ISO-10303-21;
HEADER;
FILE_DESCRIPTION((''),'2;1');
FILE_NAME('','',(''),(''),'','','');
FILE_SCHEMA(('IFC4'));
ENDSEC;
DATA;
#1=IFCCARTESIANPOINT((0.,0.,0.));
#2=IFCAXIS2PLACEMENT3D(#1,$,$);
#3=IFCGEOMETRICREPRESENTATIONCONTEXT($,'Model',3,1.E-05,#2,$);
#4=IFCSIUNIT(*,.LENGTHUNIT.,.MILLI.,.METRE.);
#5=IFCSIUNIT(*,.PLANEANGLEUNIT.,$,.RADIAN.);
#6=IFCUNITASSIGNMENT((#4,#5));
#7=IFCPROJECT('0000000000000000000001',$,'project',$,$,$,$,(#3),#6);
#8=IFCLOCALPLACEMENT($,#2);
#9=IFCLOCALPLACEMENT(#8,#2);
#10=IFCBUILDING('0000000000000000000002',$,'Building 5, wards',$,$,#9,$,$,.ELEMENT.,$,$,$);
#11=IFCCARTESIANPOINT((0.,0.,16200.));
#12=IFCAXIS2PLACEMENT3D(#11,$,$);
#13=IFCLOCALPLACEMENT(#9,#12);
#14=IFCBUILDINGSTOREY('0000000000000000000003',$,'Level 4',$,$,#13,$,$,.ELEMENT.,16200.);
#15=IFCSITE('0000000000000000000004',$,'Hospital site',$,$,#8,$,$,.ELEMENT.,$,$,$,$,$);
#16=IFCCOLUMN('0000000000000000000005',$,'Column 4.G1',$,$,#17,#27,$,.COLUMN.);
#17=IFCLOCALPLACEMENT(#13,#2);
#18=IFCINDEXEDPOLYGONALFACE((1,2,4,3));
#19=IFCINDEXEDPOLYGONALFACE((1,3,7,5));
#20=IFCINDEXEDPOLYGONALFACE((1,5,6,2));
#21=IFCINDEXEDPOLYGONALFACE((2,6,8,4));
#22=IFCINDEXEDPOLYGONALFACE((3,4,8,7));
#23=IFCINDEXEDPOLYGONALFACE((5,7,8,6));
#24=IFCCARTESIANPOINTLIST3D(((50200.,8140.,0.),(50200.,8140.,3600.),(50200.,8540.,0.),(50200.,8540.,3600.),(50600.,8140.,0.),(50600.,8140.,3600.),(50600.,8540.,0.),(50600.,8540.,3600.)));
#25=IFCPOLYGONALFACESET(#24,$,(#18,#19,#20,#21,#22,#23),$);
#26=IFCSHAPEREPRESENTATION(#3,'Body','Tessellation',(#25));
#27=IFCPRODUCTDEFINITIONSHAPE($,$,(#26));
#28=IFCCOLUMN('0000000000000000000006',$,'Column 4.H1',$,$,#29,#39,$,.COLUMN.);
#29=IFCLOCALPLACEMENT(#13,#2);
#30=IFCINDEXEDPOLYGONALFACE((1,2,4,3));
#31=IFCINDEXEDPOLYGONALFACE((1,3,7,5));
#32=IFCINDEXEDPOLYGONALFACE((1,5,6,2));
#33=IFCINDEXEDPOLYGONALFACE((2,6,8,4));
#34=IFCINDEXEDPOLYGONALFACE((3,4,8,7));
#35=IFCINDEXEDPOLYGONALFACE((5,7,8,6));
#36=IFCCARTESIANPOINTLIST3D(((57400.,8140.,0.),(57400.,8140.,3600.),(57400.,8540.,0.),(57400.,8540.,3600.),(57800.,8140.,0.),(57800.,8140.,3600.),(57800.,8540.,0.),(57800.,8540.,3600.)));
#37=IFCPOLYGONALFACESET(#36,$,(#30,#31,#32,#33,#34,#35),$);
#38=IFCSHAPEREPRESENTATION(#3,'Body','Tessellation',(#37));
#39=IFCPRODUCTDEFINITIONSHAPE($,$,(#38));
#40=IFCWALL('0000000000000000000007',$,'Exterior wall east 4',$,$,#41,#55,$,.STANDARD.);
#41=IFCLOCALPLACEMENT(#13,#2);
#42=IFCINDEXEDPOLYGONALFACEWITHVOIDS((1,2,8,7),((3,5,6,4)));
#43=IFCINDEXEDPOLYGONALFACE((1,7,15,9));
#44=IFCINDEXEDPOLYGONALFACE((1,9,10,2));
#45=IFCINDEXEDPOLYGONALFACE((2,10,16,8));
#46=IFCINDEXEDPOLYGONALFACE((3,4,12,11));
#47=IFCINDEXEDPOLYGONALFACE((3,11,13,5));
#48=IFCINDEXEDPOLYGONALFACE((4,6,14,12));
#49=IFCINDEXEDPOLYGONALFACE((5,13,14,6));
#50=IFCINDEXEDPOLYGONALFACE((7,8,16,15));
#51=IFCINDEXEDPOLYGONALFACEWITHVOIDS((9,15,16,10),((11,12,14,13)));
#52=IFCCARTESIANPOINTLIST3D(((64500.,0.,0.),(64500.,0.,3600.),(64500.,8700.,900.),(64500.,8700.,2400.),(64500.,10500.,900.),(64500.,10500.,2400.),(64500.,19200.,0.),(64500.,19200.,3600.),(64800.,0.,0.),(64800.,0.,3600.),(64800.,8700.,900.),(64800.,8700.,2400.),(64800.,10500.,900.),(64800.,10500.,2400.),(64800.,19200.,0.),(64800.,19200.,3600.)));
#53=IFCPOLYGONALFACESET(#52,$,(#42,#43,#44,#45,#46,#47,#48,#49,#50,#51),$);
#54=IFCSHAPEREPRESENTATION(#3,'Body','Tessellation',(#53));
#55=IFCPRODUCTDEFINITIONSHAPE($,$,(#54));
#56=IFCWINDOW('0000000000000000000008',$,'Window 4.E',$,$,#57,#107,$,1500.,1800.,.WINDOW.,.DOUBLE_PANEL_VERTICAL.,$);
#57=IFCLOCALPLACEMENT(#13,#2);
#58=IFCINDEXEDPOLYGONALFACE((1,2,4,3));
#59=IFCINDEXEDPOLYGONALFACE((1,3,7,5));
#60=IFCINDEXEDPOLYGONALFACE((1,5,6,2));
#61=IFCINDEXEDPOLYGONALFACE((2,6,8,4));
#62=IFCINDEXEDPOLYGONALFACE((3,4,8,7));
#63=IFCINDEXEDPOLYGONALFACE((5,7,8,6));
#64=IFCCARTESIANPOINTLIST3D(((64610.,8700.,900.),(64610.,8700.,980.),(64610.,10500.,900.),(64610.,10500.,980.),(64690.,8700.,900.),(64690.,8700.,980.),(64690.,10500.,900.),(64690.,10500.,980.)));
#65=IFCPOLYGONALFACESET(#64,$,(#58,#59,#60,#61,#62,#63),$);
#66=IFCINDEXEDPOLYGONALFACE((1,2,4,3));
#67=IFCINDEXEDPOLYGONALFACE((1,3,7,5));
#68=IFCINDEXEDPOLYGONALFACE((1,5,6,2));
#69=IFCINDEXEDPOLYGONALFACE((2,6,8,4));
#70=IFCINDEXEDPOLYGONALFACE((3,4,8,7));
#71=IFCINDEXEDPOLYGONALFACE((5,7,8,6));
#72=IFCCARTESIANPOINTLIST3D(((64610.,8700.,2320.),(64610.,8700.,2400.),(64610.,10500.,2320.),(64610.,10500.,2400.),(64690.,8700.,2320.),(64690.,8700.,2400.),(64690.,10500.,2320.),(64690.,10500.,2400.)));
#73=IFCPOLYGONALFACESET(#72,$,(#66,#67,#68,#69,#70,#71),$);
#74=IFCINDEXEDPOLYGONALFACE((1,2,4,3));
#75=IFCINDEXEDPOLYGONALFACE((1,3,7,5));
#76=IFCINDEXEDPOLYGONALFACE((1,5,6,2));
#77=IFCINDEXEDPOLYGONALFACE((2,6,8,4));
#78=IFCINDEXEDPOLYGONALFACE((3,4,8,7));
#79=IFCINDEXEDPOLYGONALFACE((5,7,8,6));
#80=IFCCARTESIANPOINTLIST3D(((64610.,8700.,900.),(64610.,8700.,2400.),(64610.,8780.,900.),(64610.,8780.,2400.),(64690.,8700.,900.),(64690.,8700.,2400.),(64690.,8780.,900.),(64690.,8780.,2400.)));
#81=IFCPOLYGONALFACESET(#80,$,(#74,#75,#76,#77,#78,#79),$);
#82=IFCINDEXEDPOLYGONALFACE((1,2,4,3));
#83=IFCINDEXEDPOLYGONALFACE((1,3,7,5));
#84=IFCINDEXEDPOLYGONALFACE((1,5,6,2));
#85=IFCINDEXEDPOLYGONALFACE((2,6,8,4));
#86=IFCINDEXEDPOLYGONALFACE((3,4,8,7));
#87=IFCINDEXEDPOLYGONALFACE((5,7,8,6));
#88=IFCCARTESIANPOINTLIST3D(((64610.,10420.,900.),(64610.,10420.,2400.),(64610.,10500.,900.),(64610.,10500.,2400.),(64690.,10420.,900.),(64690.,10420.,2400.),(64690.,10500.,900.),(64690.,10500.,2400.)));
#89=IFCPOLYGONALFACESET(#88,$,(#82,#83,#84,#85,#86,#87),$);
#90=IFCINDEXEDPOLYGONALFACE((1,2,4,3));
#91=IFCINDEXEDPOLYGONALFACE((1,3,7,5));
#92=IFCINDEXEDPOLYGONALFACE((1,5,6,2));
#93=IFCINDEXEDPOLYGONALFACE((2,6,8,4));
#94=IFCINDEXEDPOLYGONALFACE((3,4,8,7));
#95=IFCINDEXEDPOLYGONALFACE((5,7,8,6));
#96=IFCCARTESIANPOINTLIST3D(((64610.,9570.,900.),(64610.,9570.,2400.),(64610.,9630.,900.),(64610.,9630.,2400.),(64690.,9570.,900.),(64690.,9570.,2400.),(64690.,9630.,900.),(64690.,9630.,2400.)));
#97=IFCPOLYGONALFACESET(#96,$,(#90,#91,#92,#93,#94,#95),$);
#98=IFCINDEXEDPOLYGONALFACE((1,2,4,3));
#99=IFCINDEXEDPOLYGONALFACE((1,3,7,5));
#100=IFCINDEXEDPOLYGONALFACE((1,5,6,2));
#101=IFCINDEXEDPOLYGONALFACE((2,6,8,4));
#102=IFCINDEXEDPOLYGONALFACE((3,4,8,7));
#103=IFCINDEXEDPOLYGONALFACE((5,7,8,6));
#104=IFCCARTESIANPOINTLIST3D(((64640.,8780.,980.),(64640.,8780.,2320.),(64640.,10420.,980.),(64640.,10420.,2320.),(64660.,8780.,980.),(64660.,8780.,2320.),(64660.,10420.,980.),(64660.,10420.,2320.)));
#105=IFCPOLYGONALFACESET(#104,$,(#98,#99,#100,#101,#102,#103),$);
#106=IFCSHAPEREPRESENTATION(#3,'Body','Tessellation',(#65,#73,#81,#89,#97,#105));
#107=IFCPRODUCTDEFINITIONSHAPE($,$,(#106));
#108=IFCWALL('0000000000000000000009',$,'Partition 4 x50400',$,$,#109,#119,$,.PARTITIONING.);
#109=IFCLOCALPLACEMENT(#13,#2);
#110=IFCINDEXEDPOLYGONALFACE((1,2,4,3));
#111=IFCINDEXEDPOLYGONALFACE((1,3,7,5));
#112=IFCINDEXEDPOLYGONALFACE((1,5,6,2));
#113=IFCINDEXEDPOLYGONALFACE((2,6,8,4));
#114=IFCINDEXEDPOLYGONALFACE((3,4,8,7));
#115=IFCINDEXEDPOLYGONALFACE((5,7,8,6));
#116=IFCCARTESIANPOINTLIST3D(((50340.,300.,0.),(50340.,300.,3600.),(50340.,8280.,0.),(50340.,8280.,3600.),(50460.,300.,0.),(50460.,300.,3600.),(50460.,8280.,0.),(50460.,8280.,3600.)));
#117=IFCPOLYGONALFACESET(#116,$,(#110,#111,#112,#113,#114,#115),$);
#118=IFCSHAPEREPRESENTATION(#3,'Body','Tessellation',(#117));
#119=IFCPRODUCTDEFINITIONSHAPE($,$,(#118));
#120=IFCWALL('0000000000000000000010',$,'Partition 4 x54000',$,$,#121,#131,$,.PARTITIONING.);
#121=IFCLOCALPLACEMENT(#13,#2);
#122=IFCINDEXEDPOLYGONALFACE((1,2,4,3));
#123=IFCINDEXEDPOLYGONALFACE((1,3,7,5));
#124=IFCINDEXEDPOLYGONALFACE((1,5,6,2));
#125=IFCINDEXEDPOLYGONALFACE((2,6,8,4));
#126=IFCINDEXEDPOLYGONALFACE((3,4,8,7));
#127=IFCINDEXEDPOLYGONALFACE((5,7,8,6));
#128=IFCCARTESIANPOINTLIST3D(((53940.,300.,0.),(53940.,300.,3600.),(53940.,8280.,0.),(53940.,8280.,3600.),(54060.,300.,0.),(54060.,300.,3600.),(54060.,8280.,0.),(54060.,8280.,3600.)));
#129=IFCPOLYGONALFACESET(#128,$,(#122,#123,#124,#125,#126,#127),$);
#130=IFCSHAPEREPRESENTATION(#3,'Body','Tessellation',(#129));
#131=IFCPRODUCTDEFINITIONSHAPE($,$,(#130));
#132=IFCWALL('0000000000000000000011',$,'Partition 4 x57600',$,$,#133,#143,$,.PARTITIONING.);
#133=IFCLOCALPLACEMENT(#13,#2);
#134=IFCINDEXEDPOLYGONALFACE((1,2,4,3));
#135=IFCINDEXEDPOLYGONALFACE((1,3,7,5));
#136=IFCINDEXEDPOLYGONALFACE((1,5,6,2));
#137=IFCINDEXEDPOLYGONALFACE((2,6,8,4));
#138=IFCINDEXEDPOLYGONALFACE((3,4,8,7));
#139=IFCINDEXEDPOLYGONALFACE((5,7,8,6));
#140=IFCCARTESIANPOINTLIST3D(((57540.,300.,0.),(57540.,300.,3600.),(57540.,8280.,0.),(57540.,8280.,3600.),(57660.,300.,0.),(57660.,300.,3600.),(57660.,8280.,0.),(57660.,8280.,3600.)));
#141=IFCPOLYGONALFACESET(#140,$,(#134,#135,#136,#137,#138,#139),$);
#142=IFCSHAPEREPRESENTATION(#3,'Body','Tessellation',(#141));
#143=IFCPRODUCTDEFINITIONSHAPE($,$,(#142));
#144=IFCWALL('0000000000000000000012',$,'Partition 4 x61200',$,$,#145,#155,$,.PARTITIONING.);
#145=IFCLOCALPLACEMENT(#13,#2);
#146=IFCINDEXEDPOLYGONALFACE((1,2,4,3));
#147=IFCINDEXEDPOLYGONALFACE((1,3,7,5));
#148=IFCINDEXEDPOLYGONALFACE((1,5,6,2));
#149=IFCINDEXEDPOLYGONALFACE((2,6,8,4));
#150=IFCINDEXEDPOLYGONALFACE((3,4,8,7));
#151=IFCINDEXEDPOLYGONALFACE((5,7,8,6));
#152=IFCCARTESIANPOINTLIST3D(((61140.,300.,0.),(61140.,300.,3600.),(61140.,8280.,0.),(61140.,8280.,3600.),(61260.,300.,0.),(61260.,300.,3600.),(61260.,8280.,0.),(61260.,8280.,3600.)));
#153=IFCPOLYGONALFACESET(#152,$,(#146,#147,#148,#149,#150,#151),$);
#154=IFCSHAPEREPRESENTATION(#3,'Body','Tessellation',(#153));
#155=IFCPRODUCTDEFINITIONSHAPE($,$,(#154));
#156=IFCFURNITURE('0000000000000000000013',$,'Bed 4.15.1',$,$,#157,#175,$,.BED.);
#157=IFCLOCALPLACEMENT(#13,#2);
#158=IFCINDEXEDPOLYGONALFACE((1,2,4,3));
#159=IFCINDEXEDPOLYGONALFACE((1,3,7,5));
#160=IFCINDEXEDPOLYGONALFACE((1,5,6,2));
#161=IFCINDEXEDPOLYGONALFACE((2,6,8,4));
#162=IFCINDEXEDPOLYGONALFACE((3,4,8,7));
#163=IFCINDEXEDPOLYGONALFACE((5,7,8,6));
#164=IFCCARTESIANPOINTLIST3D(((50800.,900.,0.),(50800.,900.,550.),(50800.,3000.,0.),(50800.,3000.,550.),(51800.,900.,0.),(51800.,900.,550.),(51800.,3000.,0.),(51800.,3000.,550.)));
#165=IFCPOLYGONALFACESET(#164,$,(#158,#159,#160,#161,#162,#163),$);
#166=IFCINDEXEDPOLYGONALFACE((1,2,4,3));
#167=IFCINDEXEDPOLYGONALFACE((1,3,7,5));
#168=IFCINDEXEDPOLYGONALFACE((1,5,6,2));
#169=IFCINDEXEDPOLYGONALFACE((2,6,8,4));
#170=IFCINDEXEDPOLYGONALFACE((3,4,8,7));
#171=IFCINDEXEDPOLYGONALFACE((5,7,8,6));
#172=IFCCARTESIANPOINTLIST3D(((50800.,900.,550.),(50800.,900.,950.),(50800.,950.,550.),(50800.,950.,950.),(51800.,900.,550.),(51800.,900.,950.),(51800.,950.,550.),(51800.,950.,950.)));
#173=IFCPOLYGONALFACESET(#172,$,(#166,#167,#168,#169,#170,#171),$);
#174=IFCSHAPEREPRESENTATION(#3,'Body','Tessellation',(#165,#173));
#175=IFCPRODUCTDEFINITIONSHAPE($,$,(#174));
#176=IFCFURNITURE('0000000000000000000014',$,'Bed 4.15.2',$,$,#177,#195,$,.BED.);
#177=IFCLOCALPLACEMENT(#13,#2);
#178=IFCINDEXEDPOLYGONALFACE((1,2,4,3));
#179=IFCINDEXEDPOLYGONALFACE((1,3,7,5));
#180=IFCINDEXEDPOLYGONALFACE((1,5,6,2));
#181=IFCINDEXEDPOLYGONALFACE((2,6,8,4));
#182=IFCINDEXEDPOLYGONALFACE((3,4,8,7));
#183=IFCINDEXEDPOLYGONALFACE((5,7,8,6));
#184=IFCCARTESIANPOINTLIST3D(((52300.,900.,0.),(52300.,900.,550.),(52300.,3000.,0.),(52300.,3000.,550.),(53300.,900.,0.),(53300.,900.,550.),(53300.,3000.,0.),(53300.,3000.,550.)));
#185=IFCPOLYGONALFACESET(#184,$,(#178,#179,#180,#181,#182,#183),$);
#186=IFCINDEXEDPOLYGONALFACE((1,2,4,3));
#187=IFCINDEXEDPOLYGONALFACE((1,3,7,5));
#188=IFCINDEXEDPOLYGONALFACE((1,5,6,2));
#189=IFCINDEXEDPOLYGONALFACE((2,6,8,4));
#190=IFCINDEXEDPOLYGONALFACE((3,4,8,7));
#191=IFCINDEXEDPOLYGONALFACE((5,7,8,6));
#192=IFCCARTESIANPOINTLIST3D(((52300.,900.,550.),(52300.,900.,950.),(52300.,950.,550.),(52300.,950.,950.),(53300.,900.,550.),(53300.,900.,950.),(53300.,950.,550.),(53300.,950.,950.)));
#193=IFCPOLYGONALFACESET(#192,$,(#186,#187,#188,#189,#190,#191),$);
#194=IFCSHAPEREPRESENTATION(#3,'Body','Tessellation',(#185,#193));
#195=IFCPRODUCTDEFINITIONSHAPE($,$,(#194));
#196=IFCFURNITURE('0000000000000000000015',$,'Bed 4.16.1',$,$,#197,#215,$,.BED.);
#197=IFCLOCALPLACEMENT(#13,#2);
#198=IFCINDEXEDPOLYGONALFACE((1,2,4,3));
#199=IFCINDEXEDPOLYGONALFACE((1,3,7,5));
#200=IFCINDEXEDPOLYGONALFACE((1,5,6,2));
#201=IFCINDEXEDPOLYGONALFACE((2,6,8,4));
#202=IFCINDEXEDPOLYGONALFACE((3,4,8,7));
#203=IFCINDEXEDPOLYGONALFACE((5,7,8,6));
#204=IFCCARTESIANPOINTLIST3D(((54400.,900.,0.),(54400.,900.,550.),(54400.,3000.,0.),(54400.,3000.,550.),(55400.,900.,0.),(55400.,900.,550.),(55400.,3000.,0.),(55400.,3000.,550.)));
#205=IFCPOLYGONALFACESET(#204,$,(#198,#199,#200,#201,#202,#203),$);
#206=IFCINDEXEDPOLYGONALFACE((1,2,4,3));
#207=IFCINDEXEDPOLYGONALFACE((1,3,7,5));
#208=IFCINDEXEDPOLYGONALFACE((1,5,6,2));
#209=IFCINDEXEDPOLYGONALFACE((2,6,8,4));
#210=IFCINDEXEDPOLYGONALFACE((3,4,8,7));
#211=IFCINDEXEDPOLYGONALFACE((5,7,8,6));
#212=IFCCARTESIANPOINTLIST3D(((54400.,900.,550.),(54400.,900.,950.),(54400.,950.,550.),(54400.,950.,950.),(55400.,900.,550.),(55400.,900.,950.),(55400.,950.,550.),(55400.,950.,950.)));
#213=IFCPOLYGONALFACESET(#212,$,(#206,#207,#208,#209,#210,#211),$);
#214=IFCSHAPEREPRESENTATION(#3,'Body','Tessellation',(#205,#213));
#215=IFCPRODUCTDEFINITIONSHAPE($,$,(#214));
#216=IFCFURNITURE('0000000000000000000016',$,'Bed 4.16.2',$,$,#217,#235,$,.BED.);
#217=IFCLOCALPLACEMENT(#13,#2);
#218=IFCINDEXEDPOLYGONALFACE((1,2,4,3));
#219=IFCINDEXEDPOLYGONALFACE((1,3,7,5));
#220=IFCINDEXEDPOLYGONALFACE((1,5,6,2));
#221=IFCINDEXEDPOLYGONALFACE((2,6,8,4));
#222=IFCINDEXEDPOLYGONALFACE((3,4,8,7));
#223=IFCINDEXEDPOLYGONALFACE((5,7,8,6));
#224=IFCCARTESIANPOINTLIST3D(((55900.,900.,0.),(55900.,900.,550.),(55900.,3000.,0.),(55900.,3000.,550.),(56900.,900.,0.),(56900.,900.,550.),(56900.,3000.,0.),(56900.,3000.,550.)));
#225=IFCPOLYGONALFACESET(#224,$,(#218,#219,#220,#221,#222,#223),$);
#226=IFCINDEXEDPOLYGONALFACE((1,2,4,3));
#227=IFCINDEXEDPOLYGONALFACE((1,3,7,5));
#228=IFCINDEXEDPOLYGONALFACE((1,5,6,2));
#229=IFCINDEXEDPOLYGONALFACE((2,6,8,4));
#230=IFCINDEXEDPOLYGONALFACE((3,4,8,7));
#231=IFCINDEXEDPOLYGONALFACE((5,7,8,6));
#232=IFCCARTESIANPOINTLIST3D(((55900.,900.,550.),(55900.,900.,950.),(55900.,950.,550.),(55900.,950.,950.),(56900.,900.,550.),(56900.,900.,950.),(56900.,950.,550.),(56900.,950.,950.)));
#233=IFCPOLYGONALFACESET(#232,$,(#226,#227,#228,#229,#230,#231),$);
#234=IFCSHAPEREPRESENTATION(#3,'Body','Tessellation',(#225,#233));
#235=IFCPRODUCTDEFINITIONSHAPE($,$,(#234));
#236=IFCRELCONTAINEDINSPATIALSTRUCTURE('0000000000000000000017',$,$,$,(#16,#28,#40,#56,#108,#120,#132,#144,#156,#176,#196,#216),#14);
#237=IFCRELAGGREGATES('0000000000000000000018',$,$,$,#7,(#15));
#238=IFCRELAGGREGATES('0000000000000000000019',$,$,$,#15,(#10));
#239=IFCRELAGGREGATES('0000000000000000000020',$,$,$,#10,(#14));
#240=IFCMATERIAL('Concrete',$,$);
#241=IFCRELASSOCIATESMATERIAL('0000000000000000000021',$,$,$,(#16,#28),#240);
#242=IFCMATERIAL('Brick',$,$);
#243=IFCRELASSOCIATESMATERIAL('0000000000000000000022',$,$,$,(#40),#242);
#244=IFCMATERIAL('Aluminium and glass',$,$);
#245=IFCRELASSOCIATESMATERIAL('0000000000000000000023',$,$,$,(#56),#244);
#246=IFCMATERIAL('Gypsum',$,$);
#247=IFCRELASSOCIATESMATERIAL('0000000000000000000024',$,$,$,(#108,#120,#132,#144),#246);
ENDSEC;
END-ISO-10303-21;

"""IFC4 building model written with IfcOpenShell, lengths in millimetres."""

from ifc_helpers import new_model, si_unit, frame, frame_2d, origin, origin_2d, place, context, project, spatial, rectangle, extrude, material, element, fill, save


model = new_model("IFC4")

# Units and contexts
model_context = context("Model", 3, precision=1e-05, world=origin())
ifc_project = project(units=[si_unit("LENGTHUNIT", "METRE", prefix="MILLI"), si_unit("PLANEANGLEUNIT", "RADIAN")], contexts=[model_context])

# Site, building, storey
site_placement = place(None, origin())
site = spatial("IfcSite", under=ifc_project, at=site_placement, Name="Hospital site", CompositionType="ELEMENT")
building_placement = place(site_placement, origin())
building = spatial("IfcBuilding", under=site, at=building_placement, Name="Building 5, wards", CompositionType="ELEMENT")
storey_placement = place(building_placement, frame((0.0, 0.0, 16200.0)))
storey = spatial("IfcBuildingStorey", under=building, at=storey_placement, Name="Level 4", CompositionType="ELEMENT", Elevation=16200.0)

# Columns
ifc_material_1 = material(Name="Concrete")
for number, where, name in (
    (1, (50400.0, 8340.0, 0.0), "Column 4.G1"),
    (2, (57600.0, 8340.0, 0.0), "Column 4.H1"),
):
    element("IfcColumn", number, at=place(storey_placement, frame(where)), inside=storey, material=ifc_material_1, Name=name, PredefinedType="COLUMN", context=model_context, shape_type="SweptSolid", body=[
        extrude(rectangle(XDim=400.0, YDim=400.0, at=origin_2d()), origin(), (0.0, 0.0, 1.0), 3600.0),
    ])

# Wall, opening, window
ifc_material_2 = material(Name="Brick")
wall_placement = place(storey_placement, frame((64800.0, 0.0, 0.0), x_axis=(0.0, 1.0, 0.0)))
wall = element("IfcWall", 3, at=wall_placement, inside=storey, material=ifc_material_2, Name="Exterior wall east 4", PredefinedType="STANDARD", context=model_context, shape_type="SweptSolid", body=[
    extrude(rectangle(XDim=19200.0, YDim=300.0, at=frame_2d((9600.0, 150.0))), origin(), (0.0, 0.0, 1.0), 3600.0),
])
opening_placement = place(wall_placement, frame((8700.0, -50.0, 900.0)))
opening = element("IfcOpeningElement", 4, at=opening_placement, cuts=wall, PredefinedType="OPENING", context=model_context, shape_type="SweptSolid", body=[
    extrude(rectangle(XDim=1800.0, YDim=400.0, at=frame_2d((900.0, 200.0))), origin(), (0.0, 0.0, 1.0), 1500.0),
])
ifc_material_3 = material(Name="Aluminium and glass")
window_placement = place(opening_placement, frame((0.0, 160.0, 0.0)))
window = element("IfcWindow", 5, at=window_placement, inside=storey, material=ifc_material_3, Name="Window 4.E", OverallHeight=1500.0, OverallWidth=1800.0, PartitioningType="DOUBLE_PANEL_VERTICAL", PredefinedType="WINDOW", context=model_context, shape_type="SweptSolid", body=[
    extrude(rectangle(XDim=1800.0, YDim=80.0, at=frame_2d((900.0, 40.0))), origin(), (0.0, 0.0, 1.0), 80.0),
    extrude(rectangle(XDim=1800.0, YDim=80.0, at=frame_2d((900.0, 40.0))), frame((0.0, 0.0, 1420.0)), (0.0, 0.0, 1.0), 80.0),
    extrude(rectangle(XDim=80.0, YDim=80.0, at=frame_2d((40.0, 40.0))), origin(), (0.0, 0.0, 1.0), 1500.0),
    extrude(rectangle(XDim=80.0, YDim=80.0, at=frame_2d((1760.0, 40.0))), origin(), (0.0, 0.0, 1.0), 1500.0),
    extrude(rectangle(XDim=60.0, YDim=80.0, at=frame_2d((900.0, 40.0))), origin(), (0.0, 0.0, 1.0), 1500.0),
    extrude(rectangle(XDim=1640.0, YDim=20.0, at=frame_2d((900.0, 40.0))), frame((0.0, 0.0, 80.0)), (0.0, 0.0, 1.0), 1340.0),
])
fill(opening, window)

# Walls
ifc_material_4 = material(Name="Gypsum")
for number, where, x_axis, name in (
    (6, (50460.0, 300.0, 0.0), (0.0, 1.0, 0.0), "Partition 4 x50400"),
    (7, (54060.0, 300.0, 0.0), (0.0, 1.0, 0.0), "Partition 4 x54000"),
    (8, (57660.0, 300.0, 0.0), (0.0, 1.0, 0.0), "Partition 4 x57600"),
    (9, (61260.0, 300.0, 0.0), (0.0, 1.0, 0.0), "Partition 4 x61200"),
):
    element("IfcWall", number, at=place(storey_placement, frame(where, x_axis=x_axis)), inside=storey, material=ifc_material_4, Name=name, PredefinedType="PARTITIONING", context=model_context, shape_type="SweptSolid", body=[
        extrude(rectangle(XDim=7980.0, YDim=120.0, at=frame_2d((3990.0, 60.0))), origin(), (0.0, 0.0, 1.0), 3600.0),
    ])

# Furniture
for number, where, name in (
    (10, (50800.0, 900.0, 0.0), "Bed 4.15.1"),
    (11, (52300.0, 900.0, 0.0), "Bed 4.15.2"),
    (12, (54400.0, 900.0, 0.0), "Bed 4.16.1"),
    (13, (55900.0, 900.0, 0.0), "Bed 4.16.2"),
):
    element("IfcFurniture", number, at=place(storey_placement, frame(where)), inside=storey, Name=name, PredefinedType="BED", context=model_context, shape_type="SweptSolid", body=[
        extrude(rectangle(XDim=1000.0, YDim=2100.0, at=frame_2d((500.0, 1050.0))), origin(), (0.0, 0.0, 1.0), 550.0),
        extrude(rectangle(XDim=1000.0, YDim=50.0, at=frame_2d((500.0, 25.0))), frame((0.0, 0.0, 550.0)), (0.0, 0.0, 1.0), 400.0),
    ])

save(model, "model.ifc")
